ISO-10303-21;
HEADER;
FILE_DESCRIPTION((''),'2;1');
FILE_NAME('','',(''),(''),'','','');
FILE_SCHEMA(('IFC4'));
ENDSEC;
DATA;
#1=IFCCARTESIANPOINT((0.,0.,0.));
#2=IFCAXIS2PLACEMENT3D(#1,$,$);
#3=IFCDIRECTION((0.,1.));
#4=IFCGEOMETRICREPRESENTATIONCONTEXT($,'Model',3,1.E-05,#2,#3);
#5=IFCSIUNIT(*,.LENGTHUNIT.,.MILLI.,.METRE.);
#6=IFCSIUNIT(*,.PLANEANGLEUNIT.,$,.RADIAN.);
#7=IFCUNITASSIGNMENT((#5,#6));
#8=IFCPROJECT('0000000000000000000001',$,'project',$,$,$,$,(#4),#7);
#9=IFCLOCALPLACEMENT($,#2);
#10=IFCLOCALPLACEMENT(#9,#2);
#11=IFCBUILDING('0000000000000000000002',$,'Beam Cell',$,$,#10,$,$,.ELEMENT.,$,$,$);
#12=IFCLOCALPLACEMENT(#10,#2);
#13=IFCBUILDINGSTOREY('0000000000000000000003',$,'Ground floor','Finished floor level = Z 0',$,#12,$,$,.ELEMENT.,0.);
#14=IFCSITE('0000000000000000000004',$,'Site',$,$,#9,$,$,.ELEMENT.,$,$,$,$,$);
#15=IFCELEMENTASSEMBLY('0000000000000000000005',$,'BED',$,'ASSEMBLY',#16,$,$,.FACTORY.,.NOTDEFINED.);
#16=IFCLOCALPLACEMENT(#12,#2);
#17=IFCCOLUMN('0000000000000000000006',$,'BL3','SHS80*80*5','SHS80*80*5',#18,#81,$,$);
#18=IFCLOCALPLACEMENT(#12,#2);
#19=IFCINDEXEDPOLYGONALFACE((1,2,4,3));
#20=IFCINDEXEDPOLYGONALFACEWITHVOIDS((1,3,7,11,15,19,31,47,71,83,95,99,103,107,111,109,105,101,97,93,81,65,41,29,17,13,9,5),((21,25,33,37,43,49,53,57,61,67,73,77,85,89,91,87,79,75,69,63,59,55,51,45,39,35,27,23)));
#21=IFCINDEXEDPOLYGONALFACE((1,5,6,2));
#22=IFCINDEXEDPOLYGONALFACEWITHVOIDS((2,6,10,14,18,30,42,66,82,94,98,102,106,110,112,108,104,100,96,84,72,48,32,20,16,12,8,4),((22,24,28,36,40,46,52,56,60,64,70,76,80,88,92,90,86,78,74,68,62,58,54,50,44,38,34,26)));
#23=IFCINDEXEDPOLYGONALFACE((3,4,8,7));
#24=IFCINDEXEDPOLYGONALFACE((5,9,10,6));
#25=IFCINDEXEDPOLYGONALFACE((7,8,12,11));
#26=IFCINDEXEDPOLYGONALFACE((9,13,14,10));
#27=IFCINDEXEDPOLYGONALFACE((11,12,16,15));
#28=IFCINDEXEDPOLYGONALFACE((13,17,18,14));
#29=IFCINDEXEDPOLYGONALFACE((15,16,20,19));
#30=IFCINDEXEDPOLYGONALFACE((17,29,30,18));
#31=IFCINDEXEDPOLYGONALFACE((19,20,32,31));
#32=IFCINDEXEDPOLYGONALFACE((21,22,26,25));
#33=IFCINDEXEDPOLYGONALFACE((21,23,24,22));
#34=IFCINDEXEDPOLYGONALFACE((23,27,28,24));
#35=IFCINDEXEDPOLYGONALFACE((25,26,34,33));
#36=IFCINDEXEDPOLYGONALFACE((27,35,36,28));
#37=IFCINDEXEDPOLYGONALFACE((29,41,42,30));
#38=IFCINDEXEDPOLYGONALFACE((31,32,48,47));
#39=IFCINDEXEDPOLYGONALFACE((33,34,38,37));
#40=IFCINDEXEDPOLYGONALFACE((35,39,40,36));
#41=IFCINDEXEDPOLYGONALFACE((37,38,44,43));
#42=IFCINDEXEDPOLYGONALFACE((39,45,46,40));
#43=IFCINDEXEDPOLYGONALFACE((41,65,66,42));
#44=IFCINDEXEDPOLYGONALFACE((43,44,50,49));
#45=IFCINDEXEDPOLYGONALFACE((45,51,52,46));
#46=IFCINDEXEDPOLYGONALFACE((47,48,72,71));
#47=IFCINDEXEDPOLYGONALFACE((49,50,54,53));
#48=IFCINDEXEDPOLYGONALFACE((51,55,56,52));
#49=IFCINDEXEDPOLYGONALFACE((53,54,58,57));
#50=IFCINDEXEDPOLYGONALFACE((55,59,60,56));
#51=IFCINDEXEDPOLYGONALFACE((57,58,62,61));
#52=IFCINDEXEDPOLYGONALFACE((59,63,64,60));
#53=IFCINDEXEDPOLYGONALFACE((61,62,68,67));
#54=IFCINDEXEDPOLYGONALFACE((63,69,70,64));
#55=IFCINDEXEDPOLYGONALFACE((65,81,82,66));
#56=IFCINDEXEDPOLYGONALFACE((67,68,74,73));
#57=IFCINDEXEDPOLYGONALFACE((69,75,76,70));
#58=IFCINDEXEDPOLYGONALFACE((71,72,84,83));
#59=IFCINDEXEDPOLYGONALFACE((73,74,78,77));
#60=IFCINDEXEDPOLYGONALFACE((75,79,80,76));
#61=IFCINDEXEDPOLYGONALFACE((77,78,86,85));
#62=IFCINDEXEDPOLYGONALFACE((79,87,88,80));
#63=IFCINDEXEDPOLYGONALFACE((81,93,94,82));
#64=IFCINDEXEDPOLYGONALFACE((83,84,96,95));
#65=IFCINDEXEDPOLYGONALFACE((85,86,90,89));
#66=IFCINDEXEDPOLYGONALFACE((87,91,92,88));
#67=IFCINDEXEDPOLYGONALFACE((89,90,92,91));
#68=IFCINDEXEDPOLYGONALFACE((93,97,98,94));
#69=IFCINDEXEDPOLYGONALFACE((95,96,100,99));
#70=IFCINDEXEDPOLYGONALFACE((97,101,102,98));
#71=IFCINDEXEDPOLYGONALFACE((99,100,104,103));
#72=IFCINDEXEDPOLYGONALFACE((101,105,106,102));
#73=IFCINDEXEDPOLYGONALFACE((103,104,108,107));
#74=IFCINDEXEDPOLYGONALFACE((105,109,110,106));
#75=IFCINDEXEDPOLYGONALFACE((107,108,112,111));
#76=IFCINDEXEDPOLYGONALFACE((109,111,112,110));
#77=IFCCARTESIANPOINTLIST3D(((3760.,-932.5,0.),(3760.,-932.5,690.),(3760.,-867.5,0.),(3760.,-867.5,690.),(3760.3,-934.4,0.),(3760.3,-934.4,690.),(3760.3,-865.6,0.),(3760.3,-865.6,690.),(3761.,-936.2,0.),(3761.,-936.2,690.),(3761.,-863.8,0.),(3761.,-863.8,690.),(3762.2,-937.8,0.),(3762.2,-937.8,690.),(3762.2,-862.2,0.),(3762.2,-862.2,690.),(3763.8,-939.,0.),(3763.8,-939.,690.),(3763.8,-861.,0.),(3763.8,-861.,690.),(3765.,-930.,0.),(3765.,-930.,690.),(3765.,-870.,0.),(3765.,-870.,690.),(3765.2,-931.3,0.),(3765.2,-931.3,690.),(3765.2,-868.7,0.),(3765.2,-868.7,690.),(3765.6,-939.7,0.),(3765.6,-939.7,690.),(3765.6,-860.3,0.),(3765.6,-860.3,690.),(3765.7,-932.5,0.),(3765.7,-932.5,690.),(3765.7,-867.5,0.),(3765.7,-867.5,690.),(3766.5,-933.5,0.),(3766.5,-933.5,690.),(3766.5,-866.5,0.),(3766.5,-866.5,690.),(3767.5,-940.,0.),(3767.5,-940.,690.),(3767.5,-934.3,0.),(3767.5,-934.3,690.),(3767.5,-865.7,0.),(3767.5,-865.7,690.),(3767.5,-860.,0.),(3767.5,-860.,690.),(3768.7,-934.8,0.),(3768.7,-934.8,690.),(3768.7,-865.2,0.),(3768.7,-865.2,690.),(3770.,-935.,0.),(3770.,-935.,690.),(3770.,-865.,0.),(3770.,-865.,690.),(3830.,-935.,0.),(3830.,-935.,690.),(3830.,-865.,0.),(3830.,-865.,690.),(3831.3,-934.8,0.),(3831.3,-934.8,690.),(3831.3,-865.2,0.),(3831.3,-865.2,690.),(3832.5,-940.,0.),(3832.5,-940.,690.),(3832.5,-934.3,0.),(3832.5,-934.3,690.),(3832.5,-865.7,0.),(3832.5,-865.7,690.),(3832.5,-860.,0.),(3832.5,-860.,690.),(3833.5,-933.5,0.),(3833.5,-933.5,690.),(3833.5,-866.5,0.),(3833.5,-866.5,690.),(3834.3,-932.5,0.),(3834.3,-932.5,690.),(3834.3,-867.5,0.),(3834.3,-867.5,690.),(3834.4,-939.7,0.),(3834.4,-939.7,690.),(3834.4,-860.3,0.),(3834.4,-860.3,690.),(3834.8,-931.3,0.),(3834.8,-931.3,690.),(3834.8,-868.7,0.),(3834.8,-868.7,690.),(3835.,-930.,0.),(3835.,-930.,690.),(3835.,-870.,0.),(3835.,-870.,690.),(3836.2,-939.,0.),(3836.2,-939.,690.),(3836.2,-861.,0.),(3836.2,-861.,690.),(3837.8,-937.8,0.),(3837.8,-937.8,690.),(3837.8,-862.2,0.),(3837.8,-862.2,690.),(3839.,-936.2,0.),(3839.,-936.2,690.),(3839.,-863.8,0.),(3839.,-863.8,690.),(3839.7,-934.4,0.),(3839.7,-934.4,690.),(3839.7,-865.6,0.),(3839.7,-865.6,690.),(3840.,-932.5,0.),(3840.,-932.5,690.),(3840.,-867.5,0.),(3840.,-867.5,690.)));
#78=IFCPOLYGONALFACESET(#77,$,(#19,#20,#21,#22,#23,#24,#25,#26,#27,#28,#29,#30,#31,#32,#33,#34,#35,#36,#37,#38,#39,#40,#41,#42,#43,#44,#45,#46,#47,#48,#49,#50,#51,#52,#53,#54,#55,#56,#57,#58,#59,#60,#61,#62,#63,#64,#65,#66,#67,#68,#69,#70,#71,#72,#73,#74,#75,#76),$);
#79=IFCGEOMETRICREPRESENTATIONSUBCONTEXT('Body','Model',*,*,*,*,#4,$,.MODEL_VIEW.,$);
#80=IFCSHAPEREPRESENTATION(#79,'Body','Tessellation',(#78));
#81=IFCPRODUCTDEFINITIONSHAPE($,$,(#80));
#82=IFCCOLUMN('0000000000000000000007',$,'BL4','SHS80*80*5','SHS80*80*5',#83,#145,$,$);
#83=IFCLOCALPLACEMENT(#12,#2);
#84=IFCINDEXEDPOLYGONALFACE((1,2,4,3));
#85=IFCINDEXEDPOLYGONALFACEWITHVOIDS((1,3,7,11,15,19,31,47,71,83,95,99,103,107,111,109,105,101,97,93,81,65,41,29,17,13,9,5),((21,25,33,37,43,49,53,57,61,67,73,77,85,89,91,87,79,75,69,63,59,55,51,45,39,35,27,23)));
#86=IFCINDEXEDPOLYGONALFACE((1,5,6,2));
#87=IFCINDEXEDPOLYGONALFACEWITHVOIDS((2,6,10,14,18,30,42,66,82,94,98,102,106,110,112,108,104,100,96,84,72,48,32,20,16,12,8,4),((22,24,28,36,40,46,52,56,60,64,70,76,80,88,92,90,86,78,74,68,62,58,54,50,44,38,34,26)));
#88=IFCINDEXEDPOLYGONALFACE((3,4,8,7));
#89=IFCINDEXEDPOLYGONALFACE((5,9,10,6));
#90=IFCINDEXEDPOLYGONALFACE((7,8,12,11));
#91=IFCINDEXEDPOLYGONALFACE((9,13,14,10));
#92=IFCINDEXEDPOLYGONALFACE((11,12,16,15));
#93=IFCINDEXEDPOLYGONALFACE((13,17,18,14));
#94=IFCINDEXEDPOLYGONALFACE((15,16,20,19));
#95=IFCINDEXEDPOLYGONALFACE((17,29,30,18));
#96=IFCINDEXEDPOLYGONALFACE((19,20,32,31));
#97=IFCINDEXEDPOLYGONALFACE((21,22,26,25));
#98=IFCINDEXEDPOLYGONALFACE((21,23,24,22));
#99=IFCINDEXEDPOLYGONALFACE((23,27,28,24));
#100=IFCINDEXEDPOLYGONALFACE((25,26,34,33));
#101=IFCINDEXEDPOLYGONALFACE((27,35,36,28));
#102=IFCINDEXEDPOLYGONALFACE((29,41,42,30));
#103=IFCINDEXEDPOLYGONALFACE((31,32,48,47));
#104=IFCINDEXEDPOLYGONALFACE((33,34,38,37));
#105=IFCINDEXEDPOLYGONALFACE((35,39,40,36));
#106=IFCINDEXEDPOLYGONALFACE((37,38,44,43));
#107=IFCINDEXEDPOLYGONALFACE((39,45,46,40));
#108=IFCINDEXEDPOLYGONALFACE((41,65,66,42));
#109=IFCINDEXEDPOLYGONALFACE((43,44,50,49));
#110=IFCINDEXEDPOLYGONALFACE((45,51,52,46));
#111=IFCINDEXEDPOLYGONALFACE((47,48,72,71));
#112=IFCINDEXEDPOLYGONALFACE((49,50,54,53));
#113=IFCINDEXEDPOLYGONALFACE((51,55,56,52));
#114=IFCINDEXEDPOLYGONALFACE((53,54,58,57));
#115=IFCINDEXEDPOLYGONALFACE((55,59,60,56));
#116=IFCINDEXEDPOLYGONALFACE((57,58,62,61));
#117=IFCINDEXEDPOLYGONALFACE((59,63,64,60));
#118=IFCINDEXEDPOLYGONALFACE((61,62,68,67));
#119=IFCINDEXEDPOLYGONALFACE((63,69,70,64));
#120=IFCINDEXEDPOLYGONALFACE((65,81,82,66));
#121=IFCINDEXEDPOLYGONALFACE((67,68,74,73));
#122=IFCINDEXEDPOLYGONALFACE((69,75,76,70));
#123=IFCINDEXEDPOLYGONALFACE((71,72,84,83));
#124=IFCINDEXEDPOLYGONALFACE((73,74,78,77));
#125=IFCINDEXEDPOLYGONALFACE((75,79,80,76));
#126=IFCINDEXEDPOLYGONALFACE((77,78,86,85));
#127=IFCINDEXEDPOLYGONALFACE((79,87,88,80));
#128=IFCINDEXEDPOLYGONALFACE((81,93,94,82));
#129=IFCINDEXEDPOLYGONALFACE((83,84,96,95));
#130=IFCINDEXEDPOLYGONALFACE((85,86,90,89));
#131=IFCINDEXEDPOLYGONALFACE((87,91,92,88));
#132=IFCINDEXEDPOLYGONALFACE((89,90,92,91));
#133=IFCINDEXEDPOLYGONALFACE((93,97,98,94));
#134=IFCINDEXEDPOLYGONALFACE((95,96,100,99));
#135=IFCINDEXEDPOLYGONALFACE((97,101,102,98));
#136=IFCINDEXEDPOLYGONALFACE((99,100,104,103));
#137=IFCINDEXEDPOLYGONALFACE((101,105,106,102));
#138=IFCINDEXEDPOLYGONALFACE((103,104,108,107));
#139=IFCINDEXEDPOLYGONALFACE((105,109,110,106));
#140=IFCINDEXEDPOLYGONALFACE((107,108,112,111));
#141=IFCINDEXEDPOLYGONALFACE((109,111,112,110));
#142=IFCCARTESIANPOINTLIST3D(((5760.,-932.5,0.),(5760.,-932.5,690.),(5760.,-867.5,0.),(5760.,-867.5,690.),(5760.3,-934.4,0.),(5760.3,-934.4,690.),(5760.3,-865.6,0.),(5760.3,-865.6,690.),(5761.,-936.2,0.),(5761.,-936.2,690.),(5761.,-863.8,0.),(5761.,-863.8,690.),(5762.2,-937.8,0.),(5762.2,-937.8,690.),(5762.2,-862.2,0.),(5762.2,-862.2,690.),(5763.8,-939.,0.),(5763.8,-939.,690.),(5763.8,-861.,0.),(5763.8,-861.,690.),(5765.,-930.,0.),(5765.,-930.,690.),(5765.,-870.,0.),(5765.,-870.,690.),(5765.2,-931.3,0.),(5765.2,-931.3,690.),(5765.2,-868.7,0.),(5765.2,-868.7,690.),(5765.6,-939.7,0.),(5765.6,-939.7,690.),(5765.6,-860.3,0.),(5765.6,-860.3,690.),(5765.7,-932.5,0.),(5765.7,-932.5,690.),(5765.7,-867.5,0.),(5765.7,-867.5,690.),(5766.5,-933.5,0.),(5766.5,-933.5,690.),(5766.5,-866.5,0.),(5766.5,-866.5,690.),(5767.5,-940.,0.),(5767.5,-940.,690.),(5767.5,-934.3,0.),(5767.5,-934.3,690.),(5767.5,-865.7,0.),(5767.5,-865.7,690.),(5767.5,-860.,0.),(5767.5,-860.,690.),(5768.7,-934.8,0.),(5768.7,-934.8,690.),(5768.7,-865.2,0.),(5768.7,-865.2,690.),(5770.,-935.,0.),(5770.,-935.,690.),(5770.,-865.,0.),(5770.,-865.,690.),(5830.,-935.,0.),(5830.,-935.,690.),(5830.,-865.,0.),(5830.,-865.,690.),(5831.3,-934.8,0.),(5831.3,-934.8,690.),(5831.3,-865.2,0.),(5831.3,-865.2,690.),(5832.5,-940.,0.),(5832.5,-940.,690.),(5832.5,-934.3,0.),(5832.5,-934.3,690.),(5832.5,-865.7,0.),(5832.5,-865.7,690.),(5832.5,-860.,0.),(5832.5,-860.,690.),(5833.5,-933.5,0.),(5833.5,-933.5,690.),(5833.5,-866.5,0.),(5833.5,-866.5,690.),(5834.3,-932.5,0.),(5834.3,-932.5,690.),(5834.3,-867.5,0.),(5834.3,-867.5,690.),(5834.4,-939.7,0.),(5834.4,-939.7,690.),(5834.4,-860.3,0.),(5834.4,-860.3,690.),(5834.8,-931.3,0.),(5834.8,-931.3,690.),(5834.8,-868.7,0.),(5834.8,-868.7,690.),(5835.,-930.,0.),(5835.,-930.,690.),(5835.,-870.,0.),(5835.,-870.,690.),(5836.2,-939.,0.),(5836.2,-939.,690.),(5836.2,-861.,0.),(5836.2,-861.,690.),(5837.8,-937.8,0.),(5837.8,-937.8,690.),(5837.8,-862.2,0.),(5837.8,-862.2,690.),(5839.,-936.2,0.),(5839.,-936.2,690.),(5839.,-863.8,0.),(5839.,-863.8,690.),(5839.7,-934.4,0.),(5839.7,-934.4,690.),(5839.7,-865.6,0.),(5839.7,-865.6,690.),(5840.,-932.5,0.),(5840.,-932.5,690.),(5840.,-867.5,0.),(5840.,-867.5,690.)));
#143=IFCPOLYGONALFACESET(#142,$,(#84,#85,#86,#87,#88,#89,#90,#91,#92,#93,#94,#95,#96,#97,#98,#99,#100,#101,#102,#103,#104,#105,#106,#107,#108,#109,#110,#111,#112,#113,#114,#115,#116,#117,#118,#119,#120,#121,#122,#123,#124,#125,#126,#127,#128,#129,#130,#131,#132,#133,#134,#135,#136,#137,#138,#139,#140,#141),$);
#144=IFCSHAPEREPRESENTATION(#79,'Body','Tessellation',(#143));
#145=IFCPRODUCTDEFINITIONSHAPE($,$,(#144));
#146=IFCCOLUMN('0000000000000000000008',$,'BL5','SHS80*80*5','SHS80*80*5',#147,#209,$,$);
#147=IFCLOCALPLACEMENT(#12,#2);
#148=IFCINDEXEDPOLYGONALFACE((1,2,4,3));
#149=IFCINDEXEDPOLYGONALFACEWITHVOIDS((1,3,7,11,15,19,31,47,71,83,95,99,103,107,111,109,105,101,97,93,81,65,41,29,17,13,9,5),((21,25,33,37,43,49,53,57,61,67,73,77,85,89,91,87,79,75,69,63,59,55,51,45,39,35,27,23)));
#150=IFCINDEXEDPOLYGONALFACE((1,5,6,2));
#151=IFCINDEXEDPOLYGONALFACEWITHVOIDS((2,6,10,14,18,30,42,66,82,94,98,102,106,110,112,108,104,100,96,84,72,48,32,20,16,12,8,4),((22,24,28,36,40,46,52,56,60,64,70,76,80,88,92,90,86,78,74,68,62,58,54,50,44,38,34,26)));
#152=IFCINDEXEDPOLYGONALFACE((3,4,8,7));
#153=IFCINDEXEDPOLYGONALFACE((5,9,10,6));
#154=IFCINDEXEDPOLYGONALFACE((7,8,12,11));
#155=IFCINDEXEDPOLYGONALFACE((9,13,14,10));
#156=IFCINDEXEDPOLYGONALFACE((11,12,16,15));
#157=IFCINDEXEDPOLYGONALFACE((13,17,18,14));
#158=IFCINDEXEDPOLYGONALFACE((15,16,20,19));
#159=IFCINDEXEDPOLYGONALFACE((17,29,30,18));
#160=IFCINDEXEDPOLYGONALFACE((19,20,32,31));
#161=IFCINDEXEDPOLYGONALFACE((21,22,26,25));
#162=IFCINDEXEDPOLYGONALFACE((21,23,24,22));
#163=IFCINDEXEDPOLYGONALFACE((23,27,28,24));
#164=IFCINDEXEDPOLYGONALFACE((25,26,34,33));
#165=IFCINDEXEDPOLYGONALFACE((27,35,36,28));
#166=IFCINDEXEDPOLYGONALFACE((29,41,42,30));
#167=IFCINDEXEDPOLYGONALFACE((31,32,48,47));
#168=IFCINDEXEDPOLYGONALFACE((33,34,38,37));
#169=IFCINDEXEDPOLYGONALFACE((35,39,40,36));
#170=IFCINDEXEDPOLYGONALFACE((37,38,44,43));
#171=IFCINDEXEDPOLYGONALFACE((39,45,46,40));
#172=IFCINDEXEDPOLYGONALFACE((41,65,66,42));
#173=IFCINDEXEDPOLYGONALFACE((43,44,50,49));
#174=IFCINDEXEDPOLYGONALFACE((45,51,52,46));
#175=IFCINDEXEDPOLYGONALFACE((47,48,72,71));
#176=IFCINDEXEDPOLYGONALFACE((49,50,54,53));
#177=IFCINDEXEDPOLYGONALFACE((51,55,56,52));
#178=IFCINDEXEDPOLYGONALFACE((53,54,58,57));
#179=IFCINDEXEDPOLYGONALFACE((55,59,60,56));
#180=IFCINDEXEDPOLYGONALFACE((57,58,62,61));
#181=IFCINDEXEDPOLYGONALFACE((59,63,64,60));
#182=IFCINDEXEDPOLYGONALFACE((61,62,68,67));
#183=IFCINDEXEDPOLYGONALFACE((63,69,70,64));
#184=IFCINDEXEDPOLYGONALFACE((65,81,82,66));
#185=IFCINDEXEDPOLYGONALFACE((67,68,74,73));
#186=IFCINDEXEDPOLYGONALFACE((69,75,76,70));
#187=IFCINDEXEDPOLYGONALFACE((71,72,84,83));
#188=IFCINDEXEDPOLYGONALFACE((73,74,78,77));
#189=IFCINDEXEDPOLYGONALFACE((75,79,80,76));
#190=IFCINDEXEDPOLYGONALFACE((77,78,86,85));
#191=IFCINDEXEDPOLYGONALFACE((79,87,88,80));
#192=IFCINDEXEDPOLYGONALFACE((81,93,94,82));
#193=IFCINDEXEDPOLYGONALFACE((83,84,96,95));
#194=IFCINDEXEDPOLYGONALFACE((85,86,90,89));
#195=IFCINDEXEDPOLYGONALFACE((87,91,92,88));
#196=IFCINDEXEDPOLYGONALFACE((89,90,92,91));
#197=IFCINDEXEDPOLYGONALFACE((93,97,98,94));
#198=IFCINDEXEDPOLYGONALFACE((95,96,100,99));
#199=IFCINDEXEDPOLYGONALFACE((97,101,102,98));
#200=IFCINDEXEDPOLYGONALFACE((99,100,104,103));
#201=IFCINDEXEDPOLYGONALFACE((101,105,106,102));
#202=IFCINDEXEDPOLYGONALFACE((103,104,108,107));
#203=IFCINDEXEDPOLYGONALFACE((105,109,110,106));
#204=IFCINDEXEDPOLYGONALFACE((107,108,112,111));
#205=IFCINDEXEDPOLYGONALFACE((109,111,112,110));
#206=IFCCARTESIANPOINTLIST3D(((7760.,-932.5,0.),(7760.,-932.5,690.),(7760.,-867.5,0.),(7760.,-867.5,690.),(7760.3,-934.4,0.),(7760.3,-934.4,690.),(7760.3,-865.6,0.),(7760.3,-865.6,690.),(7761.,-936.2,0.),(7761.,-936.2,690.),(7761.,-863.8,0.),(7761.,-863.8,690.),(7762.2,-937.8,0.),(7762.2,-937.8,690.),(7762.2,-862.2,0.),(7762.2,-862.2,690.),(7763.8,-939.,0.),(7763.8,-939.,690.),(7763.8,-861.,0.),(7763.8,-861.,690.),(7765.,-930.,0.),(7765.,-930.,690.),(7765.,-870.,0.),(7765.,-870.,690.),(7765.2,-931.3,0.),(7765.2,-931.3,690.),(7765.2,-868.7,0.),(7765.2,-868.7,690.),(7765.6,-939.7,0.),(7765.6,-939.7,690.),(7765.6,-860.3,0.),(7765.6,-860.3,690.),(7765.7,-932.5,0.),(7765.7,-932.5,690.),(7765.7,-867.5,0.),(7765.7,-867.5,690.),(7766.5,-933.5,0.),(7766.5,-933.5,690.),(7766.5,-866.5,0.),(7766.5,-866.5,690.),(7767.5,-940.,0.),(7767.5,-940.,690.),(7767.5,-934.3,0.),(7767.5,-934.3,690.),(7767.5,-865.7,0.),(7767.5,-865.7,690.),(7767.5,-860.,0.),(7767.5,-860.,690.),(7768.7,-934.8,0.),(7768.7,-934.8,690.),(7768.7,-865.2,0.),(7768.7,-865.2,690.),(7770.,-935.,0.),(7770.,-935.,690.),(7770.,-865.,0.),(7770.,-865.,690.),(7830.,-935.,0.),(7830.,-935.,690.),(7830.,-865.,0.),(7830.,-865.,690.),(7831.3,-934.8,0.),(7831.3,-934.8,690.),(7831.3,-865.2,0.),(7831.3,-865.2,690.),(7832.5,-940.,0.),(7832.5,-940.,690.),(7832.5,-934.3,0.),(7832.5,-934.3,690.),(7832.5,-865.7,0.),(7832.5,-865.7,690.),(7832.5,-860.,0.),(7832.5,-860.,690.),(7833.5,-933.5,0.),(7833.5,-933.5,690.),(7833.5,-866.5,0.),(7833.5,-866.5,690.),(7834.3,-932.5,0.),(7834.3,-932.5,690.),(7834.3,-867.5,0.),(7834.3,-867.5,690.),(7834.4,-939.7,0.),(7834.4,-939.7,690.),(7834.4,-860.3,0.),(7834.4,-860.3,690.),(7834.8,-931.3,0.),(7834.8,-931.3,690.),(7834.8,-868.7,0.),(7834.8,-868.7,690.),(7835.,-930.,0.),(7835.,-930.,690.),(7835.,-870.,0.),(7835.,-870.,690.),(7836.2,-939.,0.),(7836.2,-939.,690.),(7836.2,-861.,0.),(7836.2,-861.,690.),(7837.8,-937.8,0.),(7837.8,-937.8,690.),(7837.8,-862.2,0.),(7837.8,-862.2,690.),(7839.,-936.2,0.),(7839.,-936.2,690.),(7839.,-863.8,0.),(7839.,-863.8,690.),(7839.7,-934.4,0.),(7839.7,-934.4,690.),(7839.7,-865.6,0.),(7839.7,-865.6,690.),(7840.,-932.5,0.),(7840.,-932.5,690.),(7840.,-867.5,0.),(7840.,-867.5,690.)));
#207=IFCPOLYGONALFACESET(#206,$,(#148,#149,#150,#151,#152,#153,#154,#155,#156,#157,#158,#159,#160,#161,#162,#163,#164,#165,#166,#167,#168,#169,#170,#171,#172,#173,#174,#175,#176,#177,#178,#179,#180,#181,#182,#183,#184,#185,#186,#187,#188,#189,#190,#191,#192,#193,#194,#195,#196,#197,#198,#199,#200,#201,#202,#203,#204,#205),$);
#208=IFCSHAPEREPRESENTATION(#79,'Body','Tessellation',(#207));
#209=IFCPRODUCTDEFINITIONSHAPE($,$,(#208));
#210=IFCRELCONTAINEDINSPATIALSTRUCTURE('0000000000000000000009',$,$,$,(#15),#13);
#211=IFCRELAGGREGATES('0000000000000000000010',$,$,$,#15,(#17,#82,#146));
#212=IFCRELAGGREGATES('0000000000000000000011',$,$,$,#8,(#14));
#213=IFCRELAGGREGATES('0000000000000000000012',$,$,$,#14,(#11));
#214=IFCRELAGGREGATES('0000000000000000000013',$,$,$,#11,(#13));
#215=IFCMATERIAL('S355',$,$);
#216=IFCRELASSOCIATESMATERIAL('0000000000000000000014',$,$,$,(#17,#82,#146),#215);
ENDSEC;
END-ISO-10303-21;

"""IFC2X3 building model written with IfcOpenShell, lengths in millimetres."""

from ifc_helpers import new_model, si_unit, direction, frame, origin, origin_2d, place, context, subcontext, project, spatial, hollow_rectangle, extrude, material, element, aggregate, save


model = new_model("IFC2X3")

# Units and contexts
model_context = context("Model", 3, precision=1e-05, world=origin(), true_north=direction((0.0, 1.0)))
body_context = subcontext(model_context, "Body", "Model", "MODEL_VIEW")
ifc_project = project(units=[si_unit("LENGTHUNIT", "METRE", prefix="MILLI"), si_unit("PLANEANGLEUNIT", "RADIAN")], contexts=[model_context])

# Site, building, storey
site_placement = place(None, origin())
site = spatial("IfcSite", under=ifc_project, at=site_placement, Name="Site", CompositionType="ELEMENT")
building_placement = place(site_placement, origin())
building = spatial("IfcBuilding", under=site, at=building_placement, Name="Beam Cell", CompositionType="ELEMENT")
storey_placement = place(building_placement, origin())
storey = spatial("IfcBuildingStorey", under=building, at=storey_placement, Name="Ground floor", Description="Finished floor level = Z 0", CompositionType="ELEMENT", Elevation=0.0)

# Element assembly, columns
ifc_material = material(Name="S355")
assembly_1_placement = place(storey_placement, origin())
assembly_1 = element("IfcElementAssembly", 1, at=assembly_1_placement, inside=storey, Name="BED", ObjectType="ASSEMBLY", AssemblyPlace="FACTORY", PredefinedType="NOTDEFINED")
column_1_placement = place(storey_placement, frame((3800.0, -900.0, 0.0), z_axis=(0.0, 0.0, 1.0), x_axis=(1.0, 0.0, 0.0)))
column_1 = element("IfcColumn", 2, at=column_1_placement, material=ifc_material, Name="BL3", Description="SHS80*80*5", ObjectType="SHS80*80*5", context=body_context, shape_type="SweptSolid", body=[
    extrude(hollow_rectangle(XDim=80.0, YDim=80.0, WallThickness=5.0, InnerFilletRadius=5.0, OuterFilletRadius=7.5, at=origin_2d()), origin(), (0.0, 0.0, 1.0), 690.0),
])
column_2_placement = place(storey_placement, frame((5800.0, -900.0, 0.0), z_axis=(0.0, 0.0, 1.0), x_axis=(1.0, 0.0, 0.0)))
column_2 = element("IfcColumn", 3, at=column_2_placement, material=ifc_material, Name="BL4", Description="SHS80*80*5", ObjectType="SHS80*80*5", context=body_context, shape_type="SweptSolid", body=[
    extrude(hollow_rectangle(XDim=80.0, YDim=80.0, WallThickness=5.0, InnerFilletRadius=5.0, OuterFilletRadius=7.5, at=origin_2d()), origin(), (0.0, 0.0, 1.0), 690.0),
])
column_3_placement = place(storey_placement, frame((7800.0, -900.0, 0.0), z_axis=(0.0, 0.0, 1.0), x_axis=(1.0, 0.0, 0.0)))
column_3 = element("IfcColumn", 4, at=column_3_placement, material=ifc_material, Name="BL5", Description="SHS80*80*5", ObjectType="SHS80*80*5", context=body_context, shape_type="SweptSolid", body=[
    extrude(hollow_rectangle(XDim=80.0, YDim=80.0, WallThickness=5.0, InnerFilletRadius=5.0, OuterFilletRadius=7.5, at=origin_2d()), origin(), (0.0, 0.0, 1.0), 690.0),
])
aggregate(assembly_1, [column_1, column_2, column_3])

save(model, "model.ifc")
